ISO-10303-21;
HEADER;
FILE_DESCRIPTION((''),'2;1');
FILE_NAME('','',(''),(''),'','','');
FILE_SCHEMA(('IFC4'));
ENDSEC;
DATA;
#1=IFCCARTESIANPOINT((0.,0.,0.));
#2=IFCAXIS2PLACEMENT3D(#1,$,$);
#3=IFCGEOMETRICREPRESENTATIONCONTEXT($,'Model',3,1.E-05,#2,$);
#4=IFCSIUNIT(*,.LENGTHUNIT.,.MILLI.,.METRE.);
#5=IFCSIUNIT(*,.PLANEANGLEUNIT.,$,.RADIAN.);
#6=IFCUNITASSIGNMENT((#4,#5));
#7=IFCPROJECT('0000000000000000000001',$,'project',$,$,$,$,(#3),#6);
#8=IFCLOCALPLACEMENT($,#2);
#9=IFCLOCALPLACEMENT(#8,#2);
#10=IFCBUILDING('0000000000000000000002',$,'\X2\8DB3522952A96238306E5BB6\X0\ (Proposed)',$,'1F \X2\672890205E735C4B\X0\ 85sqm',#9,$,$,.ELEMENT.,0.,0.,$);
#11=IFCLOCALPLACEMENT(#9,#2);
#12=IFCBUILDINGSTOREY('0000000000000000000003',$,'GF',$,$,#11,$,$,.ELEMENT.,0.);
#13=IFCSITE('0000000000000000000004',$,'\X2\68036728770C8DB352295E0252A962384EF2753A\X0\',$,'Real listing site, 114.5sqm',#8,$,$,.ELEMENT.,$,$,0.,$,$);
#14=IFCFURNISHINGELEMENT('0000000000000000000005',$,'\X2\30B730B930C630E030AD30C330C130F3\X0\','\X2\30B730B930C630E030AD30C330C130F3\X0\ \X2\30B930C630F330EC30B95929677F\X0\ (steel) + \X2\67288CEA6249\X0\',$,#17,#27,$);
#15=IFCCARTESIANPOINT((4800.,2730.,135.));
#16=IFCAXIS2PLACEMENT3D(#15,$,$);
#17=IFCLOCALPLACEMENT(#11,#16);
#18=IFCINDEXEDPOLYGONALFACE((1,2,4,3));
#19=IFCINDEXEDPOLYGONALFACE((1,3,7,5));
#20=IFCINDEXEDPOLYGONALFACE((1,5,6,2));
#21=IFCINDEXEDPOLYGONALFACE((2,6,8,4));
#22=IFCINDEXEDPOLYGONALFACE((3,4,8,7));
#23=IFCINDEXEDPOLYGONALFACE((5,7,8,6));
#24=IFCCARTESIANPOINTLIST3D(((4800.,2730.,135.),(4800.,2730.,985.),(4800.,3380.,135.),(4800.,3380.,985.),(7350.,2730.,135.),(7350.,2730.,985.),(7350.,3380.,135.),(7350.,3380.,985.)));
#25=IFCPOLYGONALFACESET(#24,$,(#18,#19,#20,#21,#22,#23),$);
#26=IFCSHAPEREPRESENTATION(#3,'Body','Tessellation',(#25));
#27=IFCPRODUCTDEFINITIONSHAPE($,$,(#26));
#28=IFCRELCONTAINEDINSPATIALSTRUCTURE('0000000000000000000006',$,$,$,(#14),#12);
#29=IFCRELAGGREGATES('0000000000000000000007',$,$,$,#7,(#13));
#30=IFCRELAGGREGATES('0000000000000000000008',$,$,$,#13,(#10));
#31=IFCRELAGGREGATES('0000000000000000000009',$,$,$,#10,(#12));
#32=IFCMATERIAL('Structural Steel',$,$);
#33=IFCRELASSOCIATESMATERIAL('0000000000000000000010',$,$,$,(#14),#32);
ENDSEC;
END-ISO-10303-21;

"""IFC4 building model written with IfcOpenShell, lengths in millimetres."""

from ifc_helpers import new_model, si_unit, frame, frame_2d, origin, place, context, project, spatial, rectangle, extrude, material, element, save


model = new_model("IFC4")

# Units and contexts
model_context = context("Model", 3, precision=1e-05, world=origin())
ifc_project = project(units=[si_unit("LENGTHUNIT", "METRE", prefix="MILLI"), si_unit("PLANEANGLEUNIT", "RADIAN")], contexts=[model_context])

# Site, building, storey
site_placement = place(None, origin())
site = spatial("IfcSite", under=ifc_project, at=site_placement, Name="栃木県足利市助戸仲町", ObjectType="Real listing site, 114.5sqm", CompositionType="ELEMENT", RefElevation=0.0)
building_placement = place(site_placement, origin())
building = spatial("IfcBuilding", under=site, at=building_placement, Name="足利助戸の家 (Proposed)", ObjectType="1F 木造平屋 85sqm", CompositionType="ELEMENT", ElevationOfRefHeight=0.0, ElevationOfTerrain=0.0)
storey_placement = place(building_placement, origin())
storey = spatial("IfcBuildingStorey", under=building, at=storey_placement, Name="GF", CompositionType="ELEMENT", Elevation=0.0)

# Furnishing element
ifc_material_1 = material(Name="Structural Steel")
furnishing_1_placement = place(storey_placement, frame((4800.0, 2730.0, 135.0)))
element("IfcFurnishingElement", 1, at=furnishing_1_placement, inside=storey, material=ifc_material_1, Name="システムキッチン", Description="システムキッチン ステンレス天板 (steel) + 木質扉", context=model_context, shape_type="SweptSolid", body=[
    extrude(rectangle(XDim=2550.0, YDim=650.0, at=frame_2d((1275.0, 325.0))), frame((4800.0, 2730.0, 135.0)), (0.0, 0.0, 1.0), 850.0),
])

save(model, "model.ifc")
